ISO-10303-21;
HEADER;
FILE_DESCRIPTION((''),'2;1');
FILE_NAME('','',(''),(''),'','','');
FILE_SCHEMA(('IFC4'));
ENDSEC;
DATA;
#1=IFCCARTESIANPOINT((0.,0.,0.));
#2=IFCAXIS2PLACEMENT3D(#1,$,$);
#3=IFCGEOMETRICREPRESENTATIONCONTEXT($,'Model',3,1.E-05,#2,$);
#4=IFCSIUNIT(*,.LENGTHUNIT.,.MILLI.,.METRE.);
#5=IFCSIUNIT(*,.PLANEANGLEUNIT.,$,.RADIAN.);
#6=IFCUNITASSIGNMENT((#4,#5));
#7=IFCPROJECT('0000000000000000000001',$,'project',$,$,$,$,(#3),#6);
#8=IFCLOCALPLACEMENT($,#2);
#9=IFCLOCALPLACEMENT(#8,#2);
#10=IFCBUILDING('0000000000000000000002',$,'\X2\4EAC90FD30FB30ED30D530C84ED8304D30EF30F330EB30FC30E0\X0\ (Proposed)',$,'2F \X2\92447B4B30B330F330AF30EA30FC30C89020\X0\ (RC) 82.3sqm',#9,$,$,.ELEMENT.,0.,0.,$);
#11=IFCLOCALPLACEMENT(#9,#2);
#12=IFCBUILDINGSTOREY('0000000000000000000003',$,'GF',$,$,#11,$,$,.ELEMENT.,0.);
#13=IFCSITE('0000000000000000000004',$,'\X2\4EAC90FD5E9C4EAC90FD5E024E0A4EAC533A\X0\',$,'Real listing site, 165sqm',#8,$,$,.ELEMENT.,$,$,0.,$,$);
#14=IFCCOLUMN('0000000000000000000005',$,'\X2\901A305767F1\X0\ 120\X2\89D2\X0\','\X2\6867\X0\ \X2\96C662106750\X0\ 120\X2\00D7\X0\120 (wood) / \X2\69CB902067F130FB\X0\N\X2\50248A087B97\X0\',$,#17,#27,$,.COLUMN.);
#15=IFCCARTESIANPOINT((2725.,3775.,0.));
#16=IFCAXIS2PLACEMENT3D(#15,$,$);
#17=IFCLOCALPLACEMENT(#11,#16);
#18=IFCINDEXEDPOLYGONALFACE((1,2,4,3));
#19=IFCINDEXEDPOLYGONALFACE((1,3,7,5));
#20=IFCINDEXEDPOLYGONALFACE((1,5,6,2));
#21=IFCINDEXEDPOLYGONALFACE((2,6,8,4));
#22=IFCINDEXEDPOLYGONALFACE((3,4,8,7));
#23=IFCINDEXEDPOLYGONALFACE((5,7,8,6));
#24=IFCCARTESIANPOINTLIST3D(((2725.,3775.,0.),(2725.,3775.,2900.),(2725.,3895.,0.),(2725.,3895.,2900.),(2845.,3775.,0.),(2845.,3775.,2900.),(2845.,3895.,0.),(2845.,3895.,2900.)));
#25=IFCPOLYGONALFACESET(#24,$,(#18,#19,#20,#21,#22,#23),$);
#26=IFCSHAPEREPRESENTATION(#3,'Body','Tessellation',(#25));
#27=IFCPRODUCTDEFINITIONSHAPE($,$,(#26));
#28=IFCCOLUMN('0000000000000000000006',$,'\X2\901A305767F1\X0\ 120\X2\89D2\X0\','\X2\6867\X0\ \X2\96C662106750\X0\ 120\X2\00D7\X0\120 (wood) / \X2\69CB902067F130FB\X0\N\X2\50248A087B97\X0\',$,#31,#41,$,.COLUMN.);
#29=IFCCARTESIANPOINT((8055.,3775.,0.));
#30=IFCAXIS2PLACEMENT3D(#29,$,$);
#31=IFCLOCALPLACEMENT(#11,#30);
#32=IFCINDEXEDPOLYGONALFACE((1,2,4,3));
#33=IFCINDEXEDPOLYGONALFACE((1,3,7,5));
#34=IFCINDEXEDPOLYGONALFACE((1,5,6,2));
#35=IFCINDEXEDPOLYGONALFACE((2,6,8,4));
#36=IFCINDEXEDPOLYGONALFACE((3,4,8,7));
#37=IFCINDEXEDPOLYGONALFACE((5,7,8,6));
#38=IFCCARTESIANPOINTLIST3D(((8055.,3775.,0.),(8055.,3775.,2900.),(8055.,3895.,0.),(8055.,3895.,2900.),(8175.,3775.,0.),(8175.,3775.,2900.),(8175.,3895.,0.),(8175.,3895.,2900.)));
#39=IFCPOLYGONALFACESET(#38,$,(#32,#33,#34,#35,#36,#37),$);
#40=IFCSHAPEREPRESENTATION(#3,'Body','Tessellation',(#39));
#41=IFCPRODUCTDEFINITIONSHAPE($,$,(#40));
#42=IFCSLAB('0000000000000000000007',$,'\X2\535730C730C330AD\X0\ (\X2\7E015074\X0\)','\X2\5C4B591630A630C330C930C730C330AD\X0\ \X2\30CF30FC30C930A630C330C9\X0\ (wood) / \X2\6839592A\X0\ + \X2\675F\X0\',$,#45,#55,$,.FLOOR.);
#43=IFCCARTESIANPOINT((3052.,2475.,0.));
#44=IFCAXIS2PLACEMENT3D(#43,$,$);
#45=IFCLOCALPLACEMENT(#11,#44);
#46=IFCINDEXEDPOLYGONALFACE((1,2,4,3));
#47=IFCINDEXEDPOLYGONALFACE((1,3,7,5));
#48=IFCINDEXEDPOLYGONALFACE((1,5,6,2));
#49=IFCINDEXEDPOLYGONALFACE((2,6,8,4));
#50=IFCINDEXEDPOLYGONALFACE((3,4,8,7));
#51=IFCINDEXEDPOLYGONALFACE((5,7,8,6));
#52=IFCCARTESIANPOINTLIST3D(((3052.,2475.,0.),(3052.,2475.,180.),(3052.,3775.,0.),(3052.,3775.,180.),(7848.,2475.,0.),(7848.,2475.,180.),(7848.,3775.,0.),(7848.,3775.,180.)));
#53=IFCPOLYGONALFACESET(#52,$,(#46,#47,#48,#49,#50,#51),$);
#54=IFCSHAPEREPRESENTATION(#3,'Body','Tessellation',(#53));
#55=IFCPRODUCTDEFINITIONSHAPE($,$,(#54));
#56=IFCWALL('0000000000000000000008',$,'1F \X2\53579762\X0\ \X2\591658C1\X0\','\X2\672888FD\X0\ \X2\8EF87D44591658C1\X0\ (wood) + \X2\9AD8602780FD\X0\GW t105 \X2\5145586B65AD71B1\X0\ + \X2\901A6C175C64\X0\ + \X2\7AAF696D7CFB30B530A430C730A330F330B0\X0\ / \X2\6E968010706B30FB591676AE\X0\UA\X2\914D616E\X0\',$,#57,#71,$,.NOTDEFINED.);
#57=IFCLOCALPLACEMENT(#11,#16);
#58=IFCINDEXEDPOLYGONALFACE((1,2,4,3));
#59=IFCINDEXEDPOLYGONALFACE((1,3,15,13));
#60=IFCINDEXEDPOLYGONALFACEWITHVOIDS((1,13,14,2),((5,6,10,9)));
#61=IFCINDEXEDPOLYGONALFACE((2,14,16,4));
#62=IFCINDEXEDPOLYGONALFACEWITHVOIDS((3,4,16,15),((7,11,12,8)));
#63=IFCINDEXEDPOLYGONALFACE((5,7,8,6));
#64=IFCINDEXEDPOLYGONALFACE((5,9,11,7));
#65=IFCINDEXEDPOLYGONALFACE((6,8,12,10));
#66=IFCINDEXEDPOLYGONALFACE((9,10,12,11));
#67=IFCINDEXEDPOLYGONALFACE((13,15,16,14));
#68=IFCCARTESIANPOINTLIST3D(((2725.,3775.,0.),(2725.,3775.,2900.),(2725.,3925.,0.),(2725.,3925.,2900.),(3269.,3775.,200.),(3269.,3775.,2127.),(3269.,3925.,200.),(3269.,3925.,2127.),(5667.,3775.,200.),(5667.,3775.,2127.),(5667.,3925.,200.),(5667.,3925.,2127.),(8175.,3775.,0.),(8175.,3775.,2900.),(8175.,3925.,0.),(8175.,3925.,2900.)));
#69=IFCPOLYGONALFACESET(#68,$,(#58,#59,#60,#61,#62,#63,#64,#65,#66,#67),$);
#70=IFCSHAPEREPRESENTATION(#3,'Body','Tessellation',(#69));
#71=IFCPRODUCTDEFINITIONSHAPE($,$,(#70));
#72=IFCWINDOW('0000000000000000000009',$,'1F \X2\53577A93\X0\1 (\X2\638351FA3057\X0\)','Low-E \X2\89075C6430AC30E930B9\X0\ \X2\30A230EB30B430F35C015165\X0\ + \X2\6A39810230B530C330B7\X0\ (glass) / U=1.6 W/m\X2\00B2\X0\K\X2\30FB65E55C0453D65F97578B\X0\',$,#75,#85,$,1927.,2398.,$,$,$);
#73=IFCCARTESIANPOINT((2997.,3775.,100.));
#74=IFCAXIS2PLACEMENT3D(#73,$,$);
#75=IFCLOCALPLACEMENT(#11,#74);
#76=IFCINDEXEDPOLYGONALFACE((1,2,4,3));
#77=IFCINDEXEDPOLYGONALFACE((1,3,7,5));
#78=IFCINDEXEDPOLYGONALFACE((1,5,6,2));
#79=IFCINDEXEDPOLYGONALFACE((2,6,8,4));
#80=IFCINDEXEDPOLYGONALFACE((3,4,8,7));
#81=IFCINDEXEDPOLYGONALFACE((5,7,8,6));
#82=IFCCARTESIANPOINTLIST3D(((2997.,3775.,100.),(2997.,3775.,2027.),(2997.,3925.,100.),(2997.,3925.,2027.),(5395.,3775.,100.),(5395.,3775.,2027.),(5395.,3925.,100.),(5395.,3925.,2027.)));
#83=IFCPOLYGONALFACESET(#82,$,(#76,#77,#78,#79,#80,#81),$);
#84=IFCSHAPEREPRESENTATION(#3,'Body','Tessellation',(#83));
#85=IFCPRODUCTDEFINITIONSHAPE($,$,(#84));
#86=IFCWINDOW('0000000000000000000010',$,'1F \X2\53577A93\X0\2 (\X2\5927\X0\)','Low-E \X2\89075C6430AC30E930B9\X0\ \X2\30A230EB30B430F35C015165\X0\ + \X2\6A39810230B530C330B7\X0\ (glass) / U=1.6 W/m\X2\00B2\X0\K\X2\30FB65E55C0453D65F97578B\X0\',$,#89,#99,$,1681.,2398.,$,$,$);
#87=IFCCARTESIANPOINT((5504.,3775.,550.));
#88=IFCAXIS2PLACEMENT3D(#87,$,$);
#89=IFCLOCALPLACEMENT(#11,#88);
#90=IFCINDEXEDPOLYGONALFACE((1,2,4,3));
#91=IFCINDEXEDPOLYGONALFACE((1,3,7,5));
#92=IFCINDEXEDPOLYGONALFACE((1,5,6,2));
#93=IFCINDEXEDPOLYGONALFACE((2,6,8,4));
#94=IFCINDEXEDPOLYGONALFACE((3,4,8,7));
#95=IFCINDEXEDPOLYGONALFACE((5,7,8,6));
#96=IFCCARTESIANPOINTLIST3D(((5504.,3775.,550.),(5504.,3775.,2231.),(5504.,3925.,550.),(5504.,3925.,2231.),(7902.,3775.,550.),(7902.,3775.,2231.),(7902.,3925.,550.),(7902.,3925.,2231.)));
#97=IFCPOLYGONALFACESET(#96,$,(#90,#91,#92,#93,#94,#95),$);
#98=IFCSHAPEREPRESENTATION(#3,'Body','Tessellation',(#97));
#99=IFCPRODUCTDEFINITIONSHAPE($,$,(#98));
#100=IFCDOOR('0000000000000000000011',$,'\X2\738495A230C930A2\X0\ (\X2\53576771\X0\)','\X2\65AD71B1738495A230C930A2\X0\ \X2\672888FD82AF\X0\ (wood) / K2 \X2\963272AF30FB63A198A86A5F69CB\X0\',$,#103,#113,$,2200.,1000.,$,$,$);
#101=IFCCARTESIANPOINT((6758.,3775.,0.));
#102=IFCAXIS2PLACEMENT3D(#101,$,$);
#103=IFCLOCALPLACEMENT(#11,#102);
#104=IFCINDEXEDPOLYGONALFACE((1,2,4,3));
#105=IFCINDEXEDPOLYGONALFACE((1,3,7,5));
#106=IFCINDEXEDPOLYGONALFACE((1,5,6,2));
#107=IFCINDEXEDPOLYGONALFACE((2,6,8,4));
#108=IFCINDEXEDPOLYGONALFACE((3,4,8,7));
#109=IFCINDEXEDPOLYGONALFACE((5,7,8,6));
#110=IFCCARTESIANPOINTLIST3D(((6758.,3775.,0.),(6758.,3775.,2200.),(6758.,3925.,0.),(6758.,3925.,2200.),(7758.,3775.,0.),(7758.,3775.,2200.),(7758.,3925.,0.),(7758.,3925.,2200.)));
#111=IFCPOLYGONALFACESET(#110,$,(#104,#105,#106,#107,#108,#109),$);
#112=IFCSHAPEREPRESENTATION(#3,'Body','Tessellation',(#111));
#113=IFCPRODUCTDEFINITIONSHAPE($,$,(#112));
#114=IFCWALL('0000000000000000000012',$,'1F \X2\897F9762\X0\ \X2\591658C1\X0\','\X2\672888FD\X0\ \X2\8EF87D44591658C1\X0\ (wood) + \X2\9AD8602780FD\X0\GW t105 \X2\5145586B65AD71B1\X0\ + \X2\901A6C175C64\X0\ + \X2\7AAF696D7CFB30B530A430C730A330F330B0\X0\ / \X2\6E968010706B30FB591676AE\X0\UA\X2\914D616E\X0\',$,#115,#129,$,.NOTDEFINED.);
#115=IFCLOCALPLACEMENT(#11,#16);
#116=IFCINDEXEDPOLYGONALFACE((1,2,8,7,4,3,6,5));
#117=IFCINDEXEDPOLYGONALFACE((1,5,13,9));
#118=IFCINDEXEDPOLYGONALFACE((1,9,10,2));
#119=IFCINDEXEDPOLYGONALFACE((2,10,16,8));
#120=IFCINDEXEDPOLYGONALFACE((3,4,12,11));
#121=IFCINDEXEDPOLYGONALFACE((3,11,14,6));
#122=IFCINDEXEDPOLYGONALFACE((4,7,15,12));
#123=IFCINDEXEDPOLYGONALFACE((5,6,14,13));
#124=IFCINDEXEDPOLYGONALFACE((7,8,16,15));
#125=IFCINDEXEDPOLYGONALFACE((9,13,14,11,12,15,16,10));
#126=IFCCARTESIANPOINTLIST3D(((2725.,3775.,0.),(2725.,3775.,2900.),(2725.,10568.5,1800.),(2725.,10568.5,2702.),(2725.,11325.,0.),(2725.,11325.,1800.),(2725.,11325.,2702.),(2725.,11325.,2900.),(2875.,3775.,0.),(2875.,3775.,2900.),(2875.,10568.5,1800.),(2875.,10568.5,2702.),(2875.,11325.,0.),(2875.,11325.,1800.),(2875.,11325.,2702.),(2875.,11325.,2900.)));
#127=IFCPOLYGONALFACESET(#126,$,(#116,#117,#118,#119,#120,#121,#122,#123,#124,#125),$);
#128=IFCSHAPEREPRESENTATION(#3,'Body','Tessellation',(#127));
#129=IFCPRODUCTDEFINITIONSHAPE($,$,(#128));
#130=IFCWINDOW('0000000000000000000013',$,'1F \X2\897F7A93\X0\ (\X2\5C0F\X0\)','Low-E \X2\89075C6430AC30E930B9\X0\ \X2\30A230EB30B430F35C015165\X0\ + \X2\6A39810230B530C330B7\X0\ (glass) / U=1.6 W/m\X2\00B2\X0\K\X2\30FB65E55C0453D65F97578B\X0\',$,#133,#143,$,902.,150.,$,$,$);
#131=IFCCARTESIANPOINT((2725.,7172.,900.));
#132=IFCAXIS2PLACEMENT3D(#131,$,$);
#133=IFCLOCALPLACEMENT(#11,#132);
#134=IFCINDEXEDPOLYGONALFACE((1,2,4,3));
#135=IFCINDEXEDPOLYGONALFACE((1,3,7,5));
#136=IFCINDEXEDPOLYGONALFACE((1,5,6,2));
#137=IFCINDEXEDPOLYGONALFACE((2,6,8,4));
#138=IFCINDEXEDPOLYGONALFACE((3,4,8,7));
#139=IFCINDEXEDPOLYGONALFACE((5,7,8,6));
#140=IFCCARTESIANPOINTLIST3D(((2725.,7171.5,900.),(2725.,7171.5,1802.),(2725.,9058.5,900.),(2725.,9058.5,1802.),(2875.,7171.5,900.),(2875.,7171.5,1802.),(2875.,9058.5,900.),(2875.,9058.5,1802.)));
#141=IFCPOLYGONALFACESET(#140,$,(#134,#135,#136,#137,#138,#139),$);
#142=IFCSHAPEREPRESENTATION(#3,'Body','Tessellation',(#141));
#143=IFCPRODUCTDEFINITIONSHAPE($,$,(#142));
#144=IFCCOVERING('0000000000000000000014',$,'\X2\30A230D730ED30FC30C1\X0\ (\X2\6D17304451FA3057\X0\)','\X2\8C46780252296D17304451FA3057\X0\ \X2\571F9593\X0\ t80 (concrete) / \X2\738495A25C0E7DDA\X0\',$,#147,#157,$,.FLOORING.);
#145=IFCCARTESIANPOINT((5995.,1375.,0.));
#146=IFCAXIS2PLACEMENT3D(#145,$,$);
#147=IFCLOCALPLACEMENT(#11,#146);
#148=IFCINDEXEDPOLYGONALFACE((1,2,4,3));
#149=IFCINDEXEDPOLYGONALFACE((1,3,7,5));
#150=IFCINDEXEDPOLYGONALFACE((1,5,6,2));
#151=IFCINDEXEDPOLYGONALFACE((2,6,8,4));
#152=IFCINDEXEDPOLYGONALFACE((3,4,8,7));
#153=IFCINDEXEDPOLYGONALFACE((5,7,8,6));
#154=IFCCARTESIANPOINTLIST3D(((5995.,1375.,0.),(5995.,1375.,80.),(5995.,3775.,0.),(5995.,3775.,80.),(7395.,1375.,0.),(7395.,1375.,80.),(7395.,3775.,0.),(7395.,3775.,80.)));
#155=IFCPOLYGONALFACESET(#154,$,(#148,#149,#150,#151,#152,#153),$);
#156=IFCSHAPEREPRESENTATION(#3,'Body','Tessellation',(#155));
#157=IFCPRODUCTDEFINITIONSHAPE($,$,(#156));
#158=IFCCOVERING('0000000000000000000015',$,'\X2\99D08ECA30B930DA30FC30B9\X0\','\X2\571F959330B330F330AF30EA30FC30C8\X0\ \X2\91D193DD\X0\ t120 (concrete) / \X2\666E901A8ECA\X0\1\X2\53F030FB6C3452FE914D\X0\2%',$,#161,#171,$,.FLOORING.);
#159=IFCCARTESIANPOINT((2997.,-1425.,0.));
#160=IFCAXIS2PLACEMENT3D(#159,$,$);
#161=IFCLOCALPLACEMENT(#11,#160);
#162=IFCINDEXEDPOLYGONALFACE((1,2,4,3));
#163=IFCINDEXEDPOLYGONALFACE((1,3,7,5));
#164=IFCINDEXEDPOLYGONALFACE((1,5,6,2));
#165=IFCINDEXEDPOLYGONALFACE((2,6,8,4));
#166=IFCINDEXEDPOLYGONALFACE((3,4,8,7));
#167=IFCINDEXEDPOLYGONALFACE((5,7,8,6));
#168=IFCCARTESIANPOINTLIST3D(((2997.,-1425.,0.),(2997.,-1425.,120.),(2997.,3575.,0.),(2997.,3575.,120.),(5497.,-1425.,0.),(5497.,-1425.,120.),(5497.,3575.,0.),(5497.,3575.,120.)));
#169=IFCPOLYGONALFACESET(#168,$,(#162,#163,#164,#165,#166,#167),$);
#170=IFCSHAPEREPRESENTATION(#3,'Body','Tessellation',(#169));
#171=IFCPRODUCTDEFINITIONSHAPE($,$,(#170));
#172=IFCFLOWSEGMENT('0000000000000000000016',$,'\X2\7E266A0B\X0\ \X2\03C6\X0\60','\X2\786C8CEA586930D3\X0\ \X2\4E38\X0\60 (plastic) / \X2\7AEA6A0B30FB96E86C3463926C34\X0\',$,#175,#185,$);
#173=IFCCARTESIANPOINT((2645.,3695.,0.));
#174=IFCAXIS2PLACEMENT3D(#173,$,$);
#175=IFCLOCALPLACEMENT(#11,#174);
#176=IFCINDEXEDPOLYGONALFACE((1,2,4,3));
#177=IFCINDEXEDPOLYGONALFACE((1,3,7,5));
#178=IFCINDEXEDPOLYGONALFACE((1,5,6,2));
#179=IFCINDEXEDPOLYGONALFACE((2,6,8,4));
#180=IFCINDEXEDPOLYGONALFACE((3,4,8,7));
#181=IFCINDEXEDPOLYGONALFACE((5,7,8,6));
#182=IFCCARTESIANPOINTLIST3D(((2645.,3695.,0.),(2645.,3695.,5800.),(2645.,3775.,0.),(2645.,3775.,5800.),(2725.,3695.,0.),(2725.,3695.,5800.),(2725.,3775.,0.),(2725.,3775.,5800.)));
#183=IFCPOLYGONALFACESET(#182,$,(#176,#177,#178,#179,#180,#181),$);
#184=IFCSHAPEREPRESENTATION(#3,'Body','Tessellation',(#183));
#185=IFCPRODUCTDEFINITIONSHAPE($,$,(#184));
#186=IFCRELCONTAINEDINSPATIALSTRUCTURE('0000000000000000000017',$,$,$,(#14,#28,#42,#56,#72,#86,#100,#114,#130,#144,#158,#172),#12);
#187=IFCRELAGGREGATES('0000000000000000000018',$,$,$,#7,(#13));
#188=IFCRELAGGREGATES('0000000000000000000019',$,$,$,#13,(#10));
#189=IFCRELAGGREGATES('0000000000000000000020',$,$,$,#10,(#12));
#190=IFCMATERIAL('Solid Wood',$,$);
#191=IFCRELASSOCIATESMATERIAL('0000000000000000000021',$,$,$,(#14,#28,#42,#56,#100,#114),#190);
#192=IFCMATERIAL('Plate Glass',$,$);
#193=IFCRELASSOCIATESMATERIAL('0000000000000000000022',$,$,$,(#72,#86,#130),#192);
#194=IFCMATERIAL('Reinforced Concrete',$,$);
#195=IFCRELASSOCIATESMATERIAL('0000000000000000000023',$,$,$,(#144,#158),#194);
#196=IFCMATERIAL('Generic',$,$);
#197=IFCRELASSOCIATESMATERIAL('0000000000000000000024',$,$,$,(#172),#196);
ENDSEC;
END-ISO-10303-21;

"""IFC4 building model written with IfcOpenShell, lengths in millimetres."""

from ifc_helpers import new_model, si_unit, frame, frame_2d, origin, place, context, project, spatial, rectangle, extrude, material, element, fill, save


model = new_model("IFC4")

# Units and contexts
model_context = context("Model", 3, precision=1e-05, world=origin())
ifc_project = project(units=[si_unit("LENGTHUNIT", "METRE", prefix="MILLI"), si_unit("PLANEANGLEUNIT", "RADIAN")], contexts=[model_context])

# Site, building, storey
site_placement = place(None, origin())
site = spatial("IfcSite", under=ifc_project, at=site_placement, Name="京都府京都市上京区", ObjectType="Real listing site, 165sqm", CompositionType="ELEMENT", RefElevation=0.0)
building_placement = place(site_placement, origin())
building = spatial("IfcBuilding", under=site, at=building_placement, Name="京都・ロフト付きワンルーム (Proposed)", ObjectType="2F 鉄筋コンクリート造 (RC) 82.3sqm", CompositionType="ELEMENT", ElevationOfRefHeight=0.0, ElevationOfTerrain=0.0)
storey_placement = place(building_placement, origin())
storey = spatial("IfcBuildingStorey", under=building, at=storey_placement, Name="GF", CompositionType="ELEMENT", Elevation=0.0)

# Columns
ifc_material_1 = material(Name="Solid Wood")
column_1_placement = place(storey_placement, frame((2725.0, 3775.0, 0.0)))
element("IfcColumn", 1, at=column_1_placement, inside=storey, material=ifc_material_1, Name="通し柱 120角", Description="桧 集成材 120×120 (wood) / 構造柱・N値計算", PredefinedType="COLUMN", context=model_context, shape_type="SweptSolid", body=[
    extrude(rectangle(XDim=120.0, YDim=120.0, at=frame_2d((60.0, 60.0))), frame((2725.0, 3775.0, 0.0)), (0.0, 0.0, 1.0), 2900.0),
])
column_2_placement = place(storey_placement, frame((8055.0, 3775.0, 0.0)))
element("IfcColumn", 2, at=column_2_placement, inside=storey, material=ifc_material_1, Name="通し柱 120角", Description="桧 集成材 120×120 (wood) / 構造柱・N値計算", PredefinedType="COLUMN", context=model_context, shape_type="SweptSolid", body=[
    extrude(rectangle(XDim=120.0, YDim=120.0, at=frame_2d((60.0, 60.0))), frame((8055.0, 3775.0, 0.0)), (0.0, 0.0, 1.0), 2900.0),
])

# Slab
ifc_material_2 = material(Name="Reinforced Concrete")
slab_1_placement = place(storey_placement, frame((3052.0, 2475.0, 0.0)))
element("IfcSlab", 3, at=slab_1_placement, inside=storey, material=ifc_material_1, Name="南デッキ (縁側)", Description="屋外ウッドデッキ ハードウッド (wood) / 根太 + 束", PredefinedType="FLOOR", context=model_context, shape_type="SweptSolid", body=[
    extrude(rectangle(XDim=4796.0, YDim=1300.0, at=frame_2d((2398.0, 650.0))), frame((3052.0, 2475.0, 0.0)), (0.0, 0.0, 1.0), 180.0),
])

# Wall, openings, windows, door
wall_1_placement = place(storey_placement, frame((2725.0, 3775.0, 0.0)))
wall_1 = element("IfcWall", 4, at=wall_1_placement, inside=storey, material=ifc_material_1, Name="1F 南面 外壁", Description="木製 軸組外壁 (wood) + 高性能GW t105 充填断熱 + 通気層 + 窯業系サイディング / 準耐火・外皮UA配慮", PredefinedType="NOTDEFINED", context=model_context, shape_type="SweptSolid", body=[
    extrude(rectangle(XDim=5450.0, YDim=150.0, at=frame_2d((2725.0, 75.0))), frame((2725.0, 3775.0, 0.0)), (0.0, 0.0, 1.0), 2900.0),
])
opening_1_placement = place(storey_placement, frame((2997.0, 3775.0, 100.0)))
opening_1 = element("IfcOpeningElement", 5, at=opening_1_placement, cuts=wall_1, PredefinedType="NOTDEFINED", context=model_context, shape_type="SweptSolid", body=[
    extrude(rectangle(XDim=2398.0, YDim=150.0, at=frame_2d((1199.0, 75.0))), frame((2997.0, 3775.0, 100.0)), (0.0, 0.0, 1.0), 1927.0),
])
opening_2_placement = place(storey_placement, frame((5504.0, 3775.0, 550.0)))
opening_2 = element("IfcOpeningElement", 6, at=opening_2_placement, cuts=wall_1, PredefinedType="NOTDEFINED", context=model_context, shape_type="SweptSolid", body=[
    extrude(rectangle(XDim=2398.0, YDim=150.0, at=frame_2d((1199.0, 75.0))), frame((5504.0, 3775.0, 550.0)), (0.0, 0.0, 1.0), 1681.0),
])
opening_3_placement = place(storey_placement, frame((6758.0, 3775.0, 0.0)))
opening_3 = element("IfcOpeningElement", 7, at=opening_3_placement, cuts=wall_1, PredefinedType="NOTDEFINED", context=model_context, shape_type="SweptSolid", body=[
    extrude(rectangle(XDim=1000.0, YDim=150.0, at=frame_2d((500.0, 75.0))), frame((6758.0, 3775.0, 0.0)), (0.0, 0.0, 1.0), 2200.0),
])
ifc_material_3 = material(Name="Plate Glass")
window_1_placement = place(storey_placement, frame((2997.0, 3775.0, 100.0)))
window_1 = element("IfcWindow", 8, at=window_1_placement, inside=storey, material=ifc_material_3, Name="1F 南窓1 (掃出し)", Description="Low-E 複層ガラス アルゴン封入 + 樹脂サッシ (glass) / U=1.6 W/m²K・日射取得型", OverallHeight=1927.0, OverallWidth=2398.0, context=model_context, shape_type="SweptSolid", body=[
    extrude(rectangle(XDim=2398.0, YDim=150.0, at=frame_2d((1199.0, 75.0))), frame((2997.0, 3775.0, 100.0)), (0.0, 0.0, 1.0), 1927.0),
])
fill(opening_1, window_1)
window_2_placement = place(storey_placement, frame((5504.0, 3775.0, 550.0)))
window_2 = element("IfcWindow", 9, at=window_2_placement, inside=storey, material=ifc_material_3, Name="1F 南窓2 (大)", Description="Low-E 複層ガラス アルゴン封入 + 樹脂サッシ (glass) / U=1.6 W/m²K・日射取得型", OverallHeight=1681.0, OverallWidth=2398.0, context=model_context, shape_type="SweptSolid", body=[
    extrude(rectangle(XDim=2398.0, YDim=150.0, at=frame_2d((1199.0, 75.0))), frame((5504.0, 3775.0, 550.0)), (0.0, 0.0, 1.0), 1681.0),
])
fill(opening_2, window_2)
door_placement = place(storey_placement, frame((6758.0, 3775.0, 0.0)))
door = element("IfcDoor", 10, at=door_placement, inside=storey, material=ifc_material_1, Name="玄関ドア (南東)", Description="断熱玄関ドア 木製芯 (wood) / K2 防犯・採風機構", OverallHeight=2200.0, OverallWidth=1000.0, context=model_context, shape_type="SweptSolid", body=[
    extrude(rectangle(XDim=1000.0, YDim=150.0, at=frame_2d((500.0, 75.0))), frame((6758.0, 3775.0, 0.0)), (0.0, 0.0, 1.0), 2200.0),
])
fill(opening_3, door)

# Wall, opening, window
wall_2_placement = place(storey_placement, frame((2725.0, 3775.0, 0.0)))
wall_2 = element("IfcWall", 11, at=wall_2_placement, inside=storey, material=ifc_material_1, Name="1F 西面 外壁", Description="木製 軸組外壁 (wood) + 高性能GW t105 充填断熱 + 通気層 + 窯業系サイディング / 準耐火・外皮UA配慮", PredefinedType="NOTDEFINED", context=model_context, shape_type="SweptSolid", body=[
    extrude(rectangle(XDim=150.0, YDim=7550.0, at=frame_2d((75.0, 3775.0))), frame((2725.0, 3775.0, 0.0)), (0.0, 0.0, 1.0), 2900.0),
])
opening_4_placement = place(storey_placement, frame((2725.0, 7172.0, 900.0)))
opening_4 = element("IfcOpeningElement", 12, at=opening_4_placement, cuts=wall_2, PredefinedType="NOTDEFINED", context=model_context, shape_type="SweptSolid", body=[
    extrude(rectangle(XDim=150.0, YDim=1887.0, at=frame_2d((75.0, 943.0))), frame((2725.0, 7172.0, 900.0)), (0.0, 0.0, 1.0), 902.0),
])
window_3_placement = place(storey_placement, frame((2725.0, 7172.0, 900.0)))
window_3 = element("IfcWindow", 13, at=window_3_placement, inside=storey, material=ifc_material_3, Name="1F 西窓 (小)", Description="Low-E 複層ガラス アルゴン封入 + 樹脂サッシ (glass) / U=1.6 W/m²K・日射取得型", OverallHeight=902.0, OverallWidth=150.0, context=model_context, shape_type="SweptSolid", body=[
    extrude(rectangle(XDim=150.0, YDim=1887.0, at=frame_2d((75.0, 943.0))), frame((2725.0, 7172.0, 900.0)), (0.0, 0.0, 1.0), 902.0),
])
fill(opening_4, window_3)

# Coverings
covering_1_placement = place(storey_placement, frame((5995.0, 1375.0, 0.0)))
element("IfcCovering", 14, at=covering_1_placement, inside=storey, material=ifc_material_2, Name="アプローチ (洗い出し)", Description="豆砂利洗い出し 土間 t80 (concrete) / 玄関導線", PredefinedType="FLOORING", context=model_context, shape_type="SweptSolid", body=[
    extrude(rectangle(XDim=1400.0, YDim=2400.0, at=frame_2d((700.0, 1200.0))), frame((5995.0, 1375.0, 0.0)), (0.0, 0.0, 1.0), 80.0),
])
covering_2_placement = place(storey_placement, frame((2997.0, -1425.0, 0.0)))
element("IfcCovering", 15, at=covering_2_placement, inside=storey, material=ifc_material_2, Name="駐車スペース", Description="土間コンクリート 金鏝 t120 (concrete) / 普通車1台・水勾配2%", PredefinedType="FLOORING", context=model_context, shape_type="SweptSolid", body=[
    extrude(rectangle(XDim=2500.0, YDim=5000.0, at=frame_2d((1250.0, 2500.0))), frame((2997.0, -1425.0, 0.0)), (0.0, 0.0, 1.0), 120.0),
])

# Flow segment
ifc_material_4 = material(Name="Generic")
flow_segment_1_placement = place(storey_placement, frame((2645.0, 3695.0, 0.0)))
element("IfcFlowSegment", 16, at=flow_segment_1_placement, inside=storey, material=ifc_material_4, Name="縦樋 φ60", Description="硬質塩ビ 丸60 (plastic) / 竪樋・雨水排水", context=model_context, shape_type="SweptSolid", body=[
    extrude(rectangle(XDim=80.0, YDim=80.0, at=frame_2d((40.0, 40.0))), frame((2645.0, 3695.0, 0.0)), (0.0, 0.0, 1.0), 5800.0),
])

save(model, "model.ifc")
